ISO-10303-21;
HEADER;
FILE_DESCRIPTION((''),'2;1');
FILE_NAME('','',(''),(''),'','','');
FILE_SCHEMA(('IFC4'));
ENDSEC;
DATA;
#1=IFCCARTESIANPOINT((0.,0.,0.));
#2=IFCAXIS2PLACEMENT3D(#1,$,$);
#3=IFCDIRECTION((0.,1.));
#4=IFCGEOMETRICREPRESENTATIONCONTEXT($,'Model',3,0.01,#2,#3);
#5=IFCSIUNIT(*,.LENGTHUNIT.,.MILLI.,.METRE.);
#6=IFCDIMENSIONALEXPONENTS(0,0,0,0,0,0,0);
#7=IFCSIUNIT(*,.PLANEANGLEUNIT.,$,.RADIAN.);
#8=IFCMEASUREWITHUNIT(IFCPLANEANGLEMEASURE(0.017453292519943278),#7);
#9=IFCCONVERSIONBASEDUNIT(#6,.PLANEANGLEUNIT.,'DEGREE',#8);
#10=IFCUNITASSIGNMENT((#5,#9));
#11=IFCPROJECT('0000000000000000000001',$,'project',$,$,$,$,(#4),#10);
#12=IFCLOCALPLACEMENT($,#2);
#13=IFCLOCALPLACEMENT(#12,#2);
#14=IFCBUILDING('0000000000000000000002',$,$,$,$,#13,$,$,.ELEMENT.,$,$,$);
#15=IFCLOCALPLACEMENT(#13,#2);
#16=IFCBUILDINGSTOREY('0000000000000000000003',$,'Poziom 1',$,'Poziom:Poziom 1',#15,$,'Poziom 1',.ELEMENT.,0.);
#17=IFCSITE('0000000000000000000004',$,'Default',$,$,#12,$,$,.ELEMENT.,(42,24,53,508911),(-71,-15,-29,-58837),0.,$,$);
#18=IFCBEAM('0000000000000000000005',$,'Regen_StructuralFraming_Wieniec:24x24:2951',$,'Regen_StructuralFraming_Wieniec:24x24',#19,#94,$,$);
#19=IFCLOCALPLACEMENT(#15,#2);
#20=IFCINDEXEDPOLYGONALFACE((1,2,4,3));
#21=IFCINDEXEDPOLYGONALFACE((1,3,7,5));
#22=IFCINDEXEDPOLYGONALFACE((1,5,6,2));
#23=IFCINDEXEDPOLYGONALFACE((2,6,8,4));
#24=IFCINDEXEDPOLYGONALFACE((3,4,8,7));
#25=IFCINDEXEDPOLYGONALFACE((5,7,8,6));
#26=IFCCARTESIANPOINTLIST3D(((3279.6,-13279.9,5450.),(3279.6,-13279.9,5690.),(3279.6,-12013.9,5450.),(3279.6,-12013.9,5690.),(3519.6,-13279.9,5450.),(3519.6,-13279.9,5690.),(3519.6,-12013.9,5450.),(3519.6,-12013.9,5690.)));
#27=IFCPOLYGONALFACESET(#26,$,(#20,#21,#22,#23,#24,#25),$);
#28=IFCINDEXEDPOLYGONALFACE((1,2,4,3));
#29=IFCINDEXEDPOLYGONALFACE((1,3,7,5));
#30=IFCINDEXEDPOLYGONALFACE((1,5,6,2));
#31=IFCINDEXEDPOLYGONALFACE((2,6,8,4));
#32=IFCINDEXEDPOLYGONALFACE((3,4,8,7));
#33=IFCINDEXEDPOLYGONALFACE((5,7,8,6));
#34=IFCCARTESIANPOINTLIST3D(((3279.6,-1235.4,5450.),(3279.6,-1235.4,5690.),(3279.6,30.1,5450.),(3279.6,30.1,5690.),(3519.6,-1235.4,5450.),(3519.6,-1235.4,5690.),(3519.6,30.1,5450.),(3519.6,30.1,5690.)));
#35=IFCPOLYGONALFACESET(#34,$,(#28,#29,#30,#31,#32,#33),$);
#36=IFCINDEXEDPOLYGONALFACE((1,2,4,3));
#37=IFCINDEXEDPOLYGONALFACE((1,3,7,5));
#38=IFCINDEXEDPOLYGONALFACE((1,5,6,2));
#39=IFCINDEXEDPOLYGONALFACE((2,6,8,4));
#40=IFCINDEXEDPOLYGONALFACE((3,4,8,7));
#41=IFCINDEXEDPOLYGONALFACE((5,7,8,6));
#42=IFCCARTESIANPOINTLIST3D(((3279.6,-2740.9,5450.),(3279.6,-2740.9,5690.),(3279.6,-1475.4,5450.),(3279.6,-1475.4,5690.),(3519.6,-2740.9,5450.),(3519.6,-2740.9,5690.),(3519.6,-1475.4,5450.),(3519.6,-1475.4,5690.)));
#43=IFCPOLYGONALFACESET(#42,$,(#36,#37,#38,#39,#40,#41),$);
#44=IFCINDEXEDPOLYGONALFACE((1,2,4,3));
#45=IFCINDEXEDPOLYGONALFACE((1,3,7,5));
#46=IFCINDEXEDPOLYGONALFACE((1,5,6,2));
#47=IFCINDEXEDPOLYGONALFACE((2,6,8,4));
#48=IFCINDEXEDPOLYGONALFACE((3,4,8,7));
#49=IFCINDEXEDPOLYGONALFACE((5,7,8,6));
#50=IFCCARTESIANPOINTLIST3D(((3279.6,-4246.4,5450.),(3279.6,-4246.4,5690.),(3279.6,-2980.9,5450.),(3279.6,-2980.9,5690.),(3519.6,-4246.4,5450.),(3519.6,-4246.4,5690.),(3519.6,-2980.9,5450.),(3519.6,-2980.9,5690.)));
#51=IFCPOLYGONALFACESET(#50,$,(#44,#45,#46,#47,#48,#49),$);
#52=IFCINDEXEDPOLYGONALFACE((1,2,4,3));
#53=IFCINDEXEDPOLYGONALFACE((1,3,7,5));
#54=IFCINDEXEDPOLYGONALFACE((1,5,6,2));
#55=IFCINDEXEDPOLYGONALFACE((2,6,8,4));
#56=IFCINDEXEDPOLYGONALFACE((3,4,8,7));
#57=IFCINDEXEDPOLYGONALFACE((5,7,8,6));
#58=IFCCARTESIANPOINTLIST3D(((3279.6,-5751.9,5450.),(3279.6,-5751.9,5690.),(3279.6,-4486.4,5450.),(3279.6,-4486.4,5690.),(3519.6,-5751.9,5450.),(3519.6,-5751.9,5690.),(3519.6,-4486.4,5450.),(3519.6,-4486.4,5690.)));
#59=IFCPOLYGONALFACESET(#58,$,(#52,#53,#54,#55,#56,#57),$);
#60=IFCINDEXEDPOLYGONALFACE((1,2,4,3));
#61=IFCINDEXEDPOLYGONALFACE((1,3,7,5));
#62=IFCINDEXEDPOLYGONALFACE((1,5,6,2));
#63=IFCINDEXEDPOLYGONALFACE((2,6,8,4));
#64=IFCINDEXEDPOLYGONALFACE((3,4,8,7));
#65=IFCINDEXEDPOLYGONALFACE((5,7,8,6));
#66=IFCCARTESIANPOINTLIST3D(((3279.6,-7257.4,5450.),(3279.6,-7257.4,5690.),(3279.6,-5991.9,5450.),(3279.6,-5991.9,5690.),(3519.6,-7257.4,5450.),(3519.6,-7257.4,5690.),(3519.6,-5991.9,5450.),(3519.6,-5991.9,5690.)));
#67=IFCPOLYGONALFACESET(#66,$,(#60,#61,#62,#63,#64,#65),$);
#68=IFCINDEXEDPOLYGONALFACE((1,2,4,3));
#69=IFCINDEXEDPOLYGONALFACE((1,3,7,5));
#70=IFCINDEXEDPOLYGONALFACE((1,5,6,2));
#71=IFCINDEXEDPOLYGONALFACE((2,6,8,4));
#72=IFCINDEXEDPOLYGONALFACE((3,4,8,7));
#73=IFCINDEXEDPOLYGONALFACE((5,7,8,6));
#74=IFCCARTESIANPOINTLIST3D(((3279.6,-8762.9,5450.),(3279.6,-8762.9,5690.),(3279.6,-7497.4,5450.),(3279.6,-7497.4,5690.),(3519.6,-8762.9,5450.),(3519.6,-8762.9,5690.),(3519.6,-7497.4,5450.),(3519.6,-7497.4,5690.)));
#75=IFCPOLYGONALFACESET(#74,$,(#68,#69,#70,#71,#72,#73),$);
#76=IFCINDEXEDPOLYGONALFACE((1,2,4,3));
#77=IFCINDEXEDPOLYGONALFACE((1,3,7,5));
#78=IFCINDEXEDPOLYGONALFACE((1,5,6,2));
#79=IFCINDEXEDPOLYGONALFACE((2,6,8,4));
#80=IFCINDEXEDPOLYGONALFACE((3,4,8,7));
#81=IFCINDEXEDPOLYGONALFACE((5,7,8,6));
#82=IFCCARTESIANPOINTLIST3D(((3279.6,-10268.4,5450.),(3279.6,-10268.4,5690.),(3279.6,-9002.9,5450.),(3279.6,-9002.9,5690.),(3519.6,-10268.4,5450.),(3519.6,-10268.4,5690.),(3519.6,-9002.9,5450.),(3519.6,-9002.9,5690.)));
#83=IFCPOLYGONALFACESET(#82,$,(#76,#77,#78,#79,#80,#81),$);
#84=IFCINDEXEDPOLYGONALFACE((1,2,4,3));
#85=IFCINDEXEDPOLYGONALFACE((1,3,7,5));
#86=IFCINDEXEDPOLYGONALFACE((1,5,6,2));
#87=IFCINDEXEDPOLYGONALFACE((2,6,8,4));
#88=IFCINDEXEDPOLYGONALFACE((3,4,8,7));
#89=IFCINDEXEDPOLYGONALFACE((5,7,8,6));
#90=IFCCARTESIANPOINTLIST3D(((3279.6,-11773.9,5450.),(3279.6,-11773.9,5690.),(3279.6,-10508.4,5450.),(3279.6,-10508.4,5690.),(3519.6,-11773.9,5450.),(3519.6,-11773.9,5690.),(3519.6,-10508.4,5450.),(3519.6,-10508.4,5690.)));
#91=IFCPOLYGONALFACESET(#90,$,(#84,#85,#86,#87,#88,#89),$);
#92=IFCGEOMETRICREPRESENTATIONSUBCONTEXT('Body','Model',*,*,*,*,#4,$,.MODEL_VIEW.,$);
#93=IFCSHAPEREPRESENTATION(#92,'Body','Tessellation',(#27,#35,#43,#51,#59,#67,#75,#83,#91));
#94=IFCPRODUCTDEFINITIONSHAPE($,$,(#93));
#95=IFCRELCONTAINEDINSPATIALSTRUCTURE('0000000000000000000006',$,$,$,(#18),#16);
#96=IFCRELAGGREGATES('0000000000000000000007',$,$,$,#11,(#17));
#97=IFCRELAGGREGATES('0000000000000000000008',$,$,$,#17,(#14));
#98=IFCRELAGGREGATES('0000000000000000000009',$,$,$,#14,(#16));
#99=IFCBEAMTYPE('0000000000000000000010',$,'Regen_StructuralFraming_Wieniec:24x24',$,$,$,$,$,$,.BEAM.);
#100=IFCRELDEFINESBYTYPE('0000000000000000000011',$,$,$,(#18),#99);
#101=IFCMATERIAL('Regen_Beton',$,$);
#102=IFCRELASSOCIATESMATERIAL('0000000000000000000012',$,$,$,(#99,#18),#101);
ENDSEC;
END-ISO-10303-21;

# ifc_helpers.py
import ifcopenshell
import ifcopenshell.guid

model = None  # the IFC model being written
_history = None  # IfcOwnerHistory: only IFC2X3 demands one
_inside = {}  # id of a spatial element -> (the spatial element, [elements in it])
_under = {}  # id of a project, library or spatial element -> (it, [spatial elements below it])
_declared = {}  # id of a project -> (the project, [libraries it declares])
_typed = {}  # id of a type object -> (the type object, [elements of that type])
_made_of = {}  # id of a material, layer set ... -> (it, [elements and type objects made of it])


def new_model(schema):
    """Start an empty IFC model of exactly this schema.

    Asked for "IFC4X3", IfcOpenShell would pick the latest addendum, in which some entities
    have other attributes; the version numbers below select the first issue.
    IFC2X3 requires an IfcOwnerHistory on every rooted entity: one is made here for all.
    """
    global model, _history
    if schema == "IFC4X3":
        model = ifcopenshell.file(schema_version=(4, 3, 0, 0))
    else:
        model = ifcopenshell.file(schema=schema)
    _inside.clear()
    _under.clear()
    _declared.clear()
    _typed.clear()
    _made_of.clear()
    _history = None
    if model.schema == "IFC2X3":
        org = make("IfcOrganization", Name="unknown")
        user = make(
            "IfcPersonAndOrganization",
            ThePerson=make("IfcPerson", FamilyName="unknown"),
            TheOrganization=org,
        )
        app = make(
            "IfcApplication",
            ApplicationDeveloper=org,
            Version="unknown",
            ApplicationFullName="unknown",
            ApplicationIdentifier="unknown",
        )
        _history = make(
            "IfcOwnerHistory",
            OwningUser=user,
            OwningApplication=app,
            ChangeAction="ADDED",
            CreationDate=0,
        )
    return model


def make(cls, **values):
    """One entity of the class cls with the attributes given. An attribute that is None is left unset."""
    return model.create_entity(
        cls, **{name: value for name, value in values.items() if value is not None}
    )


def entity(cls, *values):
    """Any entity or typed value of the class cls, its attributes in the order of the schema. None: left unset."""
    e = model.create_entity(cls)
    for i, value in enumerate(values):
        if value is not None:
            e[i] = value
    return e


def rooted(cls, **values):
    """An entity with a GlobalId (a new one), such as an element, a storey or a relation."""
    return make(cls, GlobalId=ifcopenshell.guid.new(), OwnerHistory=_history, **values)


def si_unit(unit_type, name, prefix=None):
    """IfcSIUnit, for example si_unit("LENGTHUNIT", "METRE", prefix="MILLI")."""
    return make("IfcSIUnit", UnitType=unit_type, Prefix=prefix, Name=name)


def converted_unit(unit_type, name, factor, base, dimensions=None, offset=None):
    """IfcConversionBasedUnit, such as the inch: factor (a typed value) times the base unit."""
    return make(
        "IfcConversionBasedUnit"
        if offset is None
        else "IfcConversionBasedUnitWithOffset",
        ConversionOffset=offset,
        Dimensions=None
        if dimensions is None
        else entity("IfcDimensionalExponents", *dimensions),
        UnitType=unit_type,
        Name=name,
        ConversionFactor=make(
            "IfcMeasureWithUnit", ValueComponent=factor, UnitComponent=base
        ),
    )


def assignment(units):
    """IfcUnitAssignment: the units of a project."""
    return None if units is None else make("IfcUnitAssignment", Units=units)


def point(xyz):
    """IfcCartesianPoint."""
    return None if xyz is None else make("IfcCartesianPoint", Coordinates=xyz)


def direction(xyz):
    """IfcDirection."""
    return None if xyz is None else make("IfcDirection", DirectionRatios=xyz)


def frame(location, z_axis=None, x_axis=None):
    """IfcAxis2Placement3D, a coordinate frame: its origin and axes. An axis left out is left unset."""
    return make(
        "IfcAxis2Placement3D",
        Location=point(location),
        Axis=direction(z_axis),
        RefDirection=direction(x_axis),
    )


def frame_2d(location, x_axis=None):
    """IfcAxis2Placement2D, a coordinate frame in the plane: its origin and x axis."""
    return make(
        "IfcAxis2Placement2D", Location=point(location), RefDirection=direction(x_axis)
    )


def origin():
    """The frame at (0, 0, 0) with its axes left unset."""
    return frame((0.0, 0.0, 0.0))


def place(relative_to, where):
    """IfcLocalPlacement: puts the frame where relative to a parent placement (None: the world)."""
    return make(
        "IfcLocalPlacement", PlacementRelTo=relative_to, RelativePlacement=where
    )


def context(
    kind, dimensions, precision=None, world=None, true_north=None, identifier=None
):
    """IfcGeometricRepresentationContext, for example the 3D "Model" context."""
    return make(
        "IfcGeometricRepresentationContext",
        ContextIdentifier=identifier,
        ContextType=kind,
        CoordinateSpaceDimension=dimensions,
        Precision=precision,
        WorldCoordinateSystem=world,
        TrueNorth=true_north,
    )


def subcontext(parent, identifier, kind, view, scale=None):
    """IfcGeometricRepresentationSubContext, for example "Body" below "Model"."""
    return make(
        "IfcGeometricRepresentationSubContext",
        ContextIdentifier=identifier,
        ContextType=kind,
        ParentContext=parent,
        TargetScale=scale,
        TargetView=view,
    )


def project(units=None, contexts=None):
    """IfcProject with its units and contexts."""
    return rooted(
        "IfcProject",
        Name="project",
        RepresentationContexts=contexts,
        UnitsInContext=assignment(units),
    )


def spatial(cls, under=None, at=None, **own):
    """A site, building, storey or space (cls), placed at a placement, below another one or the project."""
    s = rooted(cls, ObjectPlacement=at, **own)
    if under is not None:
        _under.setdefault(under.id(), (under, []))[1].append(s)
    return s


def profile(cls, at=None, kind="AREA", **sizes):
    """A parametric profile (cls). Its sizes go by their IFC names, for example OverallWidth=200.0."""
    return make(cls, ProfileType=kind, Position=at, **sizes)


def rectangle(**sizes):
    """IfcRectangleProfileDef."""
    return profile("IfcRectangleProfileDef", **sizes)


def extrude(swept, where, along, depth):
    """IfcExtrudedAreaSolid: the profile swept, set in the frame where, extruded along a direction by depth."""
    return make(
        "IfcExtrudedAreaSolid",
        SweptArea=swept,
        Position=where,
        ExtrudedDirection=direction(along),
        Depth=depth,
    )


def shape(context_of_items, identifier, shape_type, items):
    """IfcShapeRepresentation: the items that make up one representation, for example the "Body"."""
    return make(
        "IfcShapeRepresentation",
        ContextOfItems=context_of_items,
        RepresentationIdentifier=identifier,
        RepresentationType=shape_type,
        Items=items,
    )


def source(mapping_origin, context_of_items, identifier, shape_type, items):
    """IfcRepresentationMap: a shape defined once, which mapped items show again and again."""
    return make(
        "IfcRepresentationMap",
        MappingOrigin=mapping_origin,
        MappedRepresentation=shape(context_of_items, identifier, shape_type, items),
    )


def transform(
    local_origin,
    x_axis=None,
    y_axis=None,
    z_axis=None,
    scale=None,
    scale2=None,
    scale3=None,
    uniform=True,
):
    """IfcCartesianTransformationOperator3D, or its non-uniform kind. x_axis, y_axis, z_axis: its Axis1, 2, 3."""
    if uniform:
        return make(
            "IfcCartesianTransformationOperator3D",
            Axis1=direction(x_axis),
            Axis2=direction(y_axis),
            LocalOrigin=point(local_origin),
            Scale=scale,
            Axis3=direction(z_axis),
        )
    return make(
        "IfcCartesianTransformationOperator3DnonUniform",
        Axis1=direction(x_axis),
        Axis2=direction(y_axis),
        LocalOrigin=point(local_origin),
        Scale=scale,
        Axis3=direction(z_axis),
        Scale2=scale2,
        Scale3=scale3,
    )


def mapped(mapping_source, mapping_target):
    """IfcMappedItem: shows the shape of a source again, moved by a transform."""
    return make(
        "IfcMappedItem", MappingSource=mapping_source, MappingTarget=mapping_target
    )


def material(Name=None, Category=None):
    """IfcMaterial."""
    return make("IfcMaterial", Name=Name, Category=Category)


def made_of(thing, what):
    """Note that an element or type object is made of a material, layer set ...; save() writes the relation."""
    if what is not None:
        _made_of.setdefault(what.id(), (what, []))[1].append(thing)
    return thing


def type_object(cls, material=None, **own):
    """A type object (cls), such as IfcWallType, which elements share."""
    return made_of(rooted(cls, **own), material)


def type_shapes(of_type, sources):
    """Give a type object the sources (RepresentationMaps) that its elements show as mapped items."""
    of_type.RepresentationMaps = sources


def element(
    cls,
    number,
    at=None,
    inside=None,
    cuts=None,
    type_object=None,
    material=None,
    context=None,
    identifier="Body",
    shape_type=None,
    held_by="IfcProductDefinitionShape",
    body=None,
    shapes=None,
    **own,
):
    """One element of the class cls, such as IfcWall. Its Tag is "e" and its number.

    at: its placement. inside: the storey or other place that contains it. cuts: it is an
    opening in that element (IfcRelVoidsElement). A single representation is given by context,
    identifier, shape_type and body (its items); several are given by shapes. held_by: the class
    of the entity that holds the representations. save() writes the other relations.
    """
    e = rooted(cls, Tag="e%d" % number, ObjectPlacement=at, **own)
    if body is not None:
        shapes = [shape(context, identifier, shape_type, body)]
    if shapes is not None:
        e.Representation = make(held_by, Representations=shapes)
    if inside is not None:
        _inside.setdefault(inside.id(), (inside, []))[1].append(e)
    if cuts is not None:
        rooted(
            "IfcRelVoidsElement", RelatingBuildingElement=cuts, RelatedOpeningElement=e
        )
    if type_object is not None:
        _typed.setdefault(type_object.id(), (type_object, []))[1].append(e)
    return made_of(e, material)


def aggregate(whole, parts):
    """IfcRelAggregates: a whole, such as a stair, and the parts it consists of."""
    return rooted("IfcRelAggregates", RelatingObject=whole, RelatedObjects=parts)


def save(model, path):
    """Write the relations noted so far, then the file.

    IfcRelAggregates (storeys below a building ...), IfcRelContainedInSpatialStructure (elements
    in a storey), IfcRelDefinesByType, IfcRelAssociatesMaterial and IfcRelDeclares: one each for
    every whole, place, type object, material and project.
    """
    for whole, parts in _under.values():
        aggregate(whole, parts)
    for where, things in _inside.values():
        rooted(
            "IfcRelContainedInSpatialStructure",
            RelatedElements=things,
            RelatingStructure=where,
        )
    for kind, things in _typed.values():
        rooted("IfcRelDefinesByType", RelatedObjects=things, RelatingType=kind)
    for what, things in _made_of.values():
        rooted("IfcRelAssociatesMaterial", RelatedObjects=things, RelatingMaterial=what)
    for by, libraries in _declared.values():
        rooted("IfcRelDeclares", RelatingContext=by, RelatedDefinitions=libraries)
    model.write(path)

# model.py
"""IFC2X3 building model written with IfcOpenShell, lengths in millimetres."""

from ifc_helpers import new_model, entity, si_unit, converted_unit, direction, frame, frame_2d, origin, place, context, subcontext, project, spatial, rectangle, extrude, source, transform, mapped, material, type_object, type_shapes, element, save


model = new_model("IFC2X3")

# Units and contexts
model_context = context("Model", 3, precision=0.01, world=origin(), true_north=direction((0.0, 1.0)))
body_context = subcontext(model_context, "Body", "Model", "MODEL_VIEW")
ifc_project = project(units=[si_unit("LENGTHUNIT", "METRE", prefix="MILLI"), converted_unit("PLANEANGLEUNIT", "DEGREE", entity("IfcPlaneAngleMeasure", 0.017453292519943278), si_unit("PLANEANGLEUNIT", "RADIAN"), dimensions=[0, 0, 0, 0, 0, 0, 0])], contexts=[model_context])

# Site, building, storey
site_placement = place(None, origin())
site = spatial("IfcSite", under=ifc_project, at=site_placement, Name="Default", CompositionType="ELEMENT", RefLatitude=(42, 24, 53, 508911), RefLongitude=(-71, -15, -29, -58837), RefElevation=0.0)
building_placement = place(site_placement, origin())
building = spatial("IfcBuilding", under=site, at=building_placement, CompositionType="ELEMENT")
storey_placement = place(building_placement, origin())
storey = spatial("IfcBuildingStorey", under=building, at=storey_placement, Name="Poziom 1", ObjectType="Poziom:Poziom 1", LongName="Poziom 1", CompositionType="ELEMENT", Elevation=0.0)

# Shared definitions
ifc_material_1 = material(Name="Regen_Beton")

# Beam
beam_type_1 = type_object("IfcBeamType", Name="Regen_StructuralFraming_Wieniec:24x24", PredefinedType="BEAM", material=ifc_material_1)
shared_shape_1 = source(origin(), body_context, "Body", "SweptSolid", [
    extrude(rectangle(XDim=240.0, YDim=240.0, at=frame_2d((0.0, 0.0), x_axis=(0.0, 1.0))), frame((3399.6, -12013.9, 5570.0), z_axis=(0.0, -1.0, 0.0), x_axis=(-1.0, 0.0, 0.0)), (0.0, 0.0, 1.0), 1266.0),
    extrude(rectangle(XDim=240.0, YDim=240.0, at=frame_2d((0.0, 0.0), x_axis=(0.0, 1.0))), frame((3399.6, 30.1, 5570.0), z_axis=(0.0, -1.0, 0.0), x_axis=(-1.0, 0.0, 0.0)), (0.0, 0.0, 1.0), 1265.5),
    extrude(rectangle(XDim=240.0, YDim=240.0, at=frame_2d((0.0, 0.0), x_axis=(0.0, 1.0))), frame((3399.6, -1475.4, 5570.0), z_axis=(0.0, -1.0, 0.0), x_axis=(-1.0, 0.0, 0.0)), (0.0, 0.0, 1.0), 1265.5),
    extrude(rectangle(XDim=240.0, YDim=240.0, at=frame_2d((0.0, 0.0), x_axis=(0.0, 1.0))), frame((3399.6, -2980.9, 5570.0), z_axis=(0.0, -1.0, 0.0), x_axis=(-1.0, 0.0, 0.0)), (0.0, 0.0, 1.0), 1265.5),
    extrude(rectangle(XDim=240.0, YDim=240.0, at=frame_2d((0.0, 0.0), x_axis=(0.0, 1.0))), frame((3399.6, -4486.4, 5570.0), z_axis=(0.0, -1.0, 0.0), x_axis=(-1.0, 0.0, 0.0)), (0.0, 0.0, 1.0), 1265.5),
    extrude(rectangle(XDim=240.0, YDim=240.0, at=frame_2d((0.0, 0.0), x_axis=(0.0, 1.0))), frame((3399.6, -5991.9, 5570.0), z_axis=(0.0, -1.0, 0.0), x_axis=(-1.0, 0.0, 0.0)), (0.0, 0.0, 1.0), 1265.5),
    extrude(rectangle(XDim=240.0, YDim=240.0, at=frame_2d((0.0, 0.0), x_axis=(0.0, 1.0))), frame((3399.6, -7497.4, 5570.0), z_axis=(0.0, -1.0, 0.0), x_axis=(-1.0, 0.0, 0.0)), (0.0, 0.0, 1.0), 1265.5),
    extrude(rectangle(XDim=240.0, YDim=240.0, at=frame_2d((0.0, 0.0), x_axis=(0.0, 1.0))), frame((3399.6, -9002.9, 5570.0), z_axis=(0.0, -1.0, 0.0), x_axis=(-1.0, 0.0, 0.0)), (0.0, 0.0, 1.0), 1265.5),
    extrude(rectangle(XDim=240.0, YDim=240.0, at=frame_2d((0.0, 0.0), x_axis=(0.0, 1.0))), frame((3399.6, -10508.4, 5570.0), z_axis=(0.0, -1.0, 0.0), x_axis=(-1.0, 0.0, 0.0)), (0.0, 0.0, 1.0), 1265.5),
])
type_shapes(beam_type_1, [shared_shape_1])
beam_1_placement = place(storey_placement, origin())
element("IfcBeam", 1, at=beam_1_placement, inside=storey, type_object=beam_type_1, material=ifc_material_1, Name="Regen_StructuralFraming_Wieniec:24x24:2951", ObjectType="Regen_StructuralFraming_Wieniec:24x24", context=body_context, shape_type="MappedRepresentation", body=[
    mapped(shared_shape_1, transform((0.0, 0.0, 0.0), scale=1.0)),
])

save(model, "model.ifc")
